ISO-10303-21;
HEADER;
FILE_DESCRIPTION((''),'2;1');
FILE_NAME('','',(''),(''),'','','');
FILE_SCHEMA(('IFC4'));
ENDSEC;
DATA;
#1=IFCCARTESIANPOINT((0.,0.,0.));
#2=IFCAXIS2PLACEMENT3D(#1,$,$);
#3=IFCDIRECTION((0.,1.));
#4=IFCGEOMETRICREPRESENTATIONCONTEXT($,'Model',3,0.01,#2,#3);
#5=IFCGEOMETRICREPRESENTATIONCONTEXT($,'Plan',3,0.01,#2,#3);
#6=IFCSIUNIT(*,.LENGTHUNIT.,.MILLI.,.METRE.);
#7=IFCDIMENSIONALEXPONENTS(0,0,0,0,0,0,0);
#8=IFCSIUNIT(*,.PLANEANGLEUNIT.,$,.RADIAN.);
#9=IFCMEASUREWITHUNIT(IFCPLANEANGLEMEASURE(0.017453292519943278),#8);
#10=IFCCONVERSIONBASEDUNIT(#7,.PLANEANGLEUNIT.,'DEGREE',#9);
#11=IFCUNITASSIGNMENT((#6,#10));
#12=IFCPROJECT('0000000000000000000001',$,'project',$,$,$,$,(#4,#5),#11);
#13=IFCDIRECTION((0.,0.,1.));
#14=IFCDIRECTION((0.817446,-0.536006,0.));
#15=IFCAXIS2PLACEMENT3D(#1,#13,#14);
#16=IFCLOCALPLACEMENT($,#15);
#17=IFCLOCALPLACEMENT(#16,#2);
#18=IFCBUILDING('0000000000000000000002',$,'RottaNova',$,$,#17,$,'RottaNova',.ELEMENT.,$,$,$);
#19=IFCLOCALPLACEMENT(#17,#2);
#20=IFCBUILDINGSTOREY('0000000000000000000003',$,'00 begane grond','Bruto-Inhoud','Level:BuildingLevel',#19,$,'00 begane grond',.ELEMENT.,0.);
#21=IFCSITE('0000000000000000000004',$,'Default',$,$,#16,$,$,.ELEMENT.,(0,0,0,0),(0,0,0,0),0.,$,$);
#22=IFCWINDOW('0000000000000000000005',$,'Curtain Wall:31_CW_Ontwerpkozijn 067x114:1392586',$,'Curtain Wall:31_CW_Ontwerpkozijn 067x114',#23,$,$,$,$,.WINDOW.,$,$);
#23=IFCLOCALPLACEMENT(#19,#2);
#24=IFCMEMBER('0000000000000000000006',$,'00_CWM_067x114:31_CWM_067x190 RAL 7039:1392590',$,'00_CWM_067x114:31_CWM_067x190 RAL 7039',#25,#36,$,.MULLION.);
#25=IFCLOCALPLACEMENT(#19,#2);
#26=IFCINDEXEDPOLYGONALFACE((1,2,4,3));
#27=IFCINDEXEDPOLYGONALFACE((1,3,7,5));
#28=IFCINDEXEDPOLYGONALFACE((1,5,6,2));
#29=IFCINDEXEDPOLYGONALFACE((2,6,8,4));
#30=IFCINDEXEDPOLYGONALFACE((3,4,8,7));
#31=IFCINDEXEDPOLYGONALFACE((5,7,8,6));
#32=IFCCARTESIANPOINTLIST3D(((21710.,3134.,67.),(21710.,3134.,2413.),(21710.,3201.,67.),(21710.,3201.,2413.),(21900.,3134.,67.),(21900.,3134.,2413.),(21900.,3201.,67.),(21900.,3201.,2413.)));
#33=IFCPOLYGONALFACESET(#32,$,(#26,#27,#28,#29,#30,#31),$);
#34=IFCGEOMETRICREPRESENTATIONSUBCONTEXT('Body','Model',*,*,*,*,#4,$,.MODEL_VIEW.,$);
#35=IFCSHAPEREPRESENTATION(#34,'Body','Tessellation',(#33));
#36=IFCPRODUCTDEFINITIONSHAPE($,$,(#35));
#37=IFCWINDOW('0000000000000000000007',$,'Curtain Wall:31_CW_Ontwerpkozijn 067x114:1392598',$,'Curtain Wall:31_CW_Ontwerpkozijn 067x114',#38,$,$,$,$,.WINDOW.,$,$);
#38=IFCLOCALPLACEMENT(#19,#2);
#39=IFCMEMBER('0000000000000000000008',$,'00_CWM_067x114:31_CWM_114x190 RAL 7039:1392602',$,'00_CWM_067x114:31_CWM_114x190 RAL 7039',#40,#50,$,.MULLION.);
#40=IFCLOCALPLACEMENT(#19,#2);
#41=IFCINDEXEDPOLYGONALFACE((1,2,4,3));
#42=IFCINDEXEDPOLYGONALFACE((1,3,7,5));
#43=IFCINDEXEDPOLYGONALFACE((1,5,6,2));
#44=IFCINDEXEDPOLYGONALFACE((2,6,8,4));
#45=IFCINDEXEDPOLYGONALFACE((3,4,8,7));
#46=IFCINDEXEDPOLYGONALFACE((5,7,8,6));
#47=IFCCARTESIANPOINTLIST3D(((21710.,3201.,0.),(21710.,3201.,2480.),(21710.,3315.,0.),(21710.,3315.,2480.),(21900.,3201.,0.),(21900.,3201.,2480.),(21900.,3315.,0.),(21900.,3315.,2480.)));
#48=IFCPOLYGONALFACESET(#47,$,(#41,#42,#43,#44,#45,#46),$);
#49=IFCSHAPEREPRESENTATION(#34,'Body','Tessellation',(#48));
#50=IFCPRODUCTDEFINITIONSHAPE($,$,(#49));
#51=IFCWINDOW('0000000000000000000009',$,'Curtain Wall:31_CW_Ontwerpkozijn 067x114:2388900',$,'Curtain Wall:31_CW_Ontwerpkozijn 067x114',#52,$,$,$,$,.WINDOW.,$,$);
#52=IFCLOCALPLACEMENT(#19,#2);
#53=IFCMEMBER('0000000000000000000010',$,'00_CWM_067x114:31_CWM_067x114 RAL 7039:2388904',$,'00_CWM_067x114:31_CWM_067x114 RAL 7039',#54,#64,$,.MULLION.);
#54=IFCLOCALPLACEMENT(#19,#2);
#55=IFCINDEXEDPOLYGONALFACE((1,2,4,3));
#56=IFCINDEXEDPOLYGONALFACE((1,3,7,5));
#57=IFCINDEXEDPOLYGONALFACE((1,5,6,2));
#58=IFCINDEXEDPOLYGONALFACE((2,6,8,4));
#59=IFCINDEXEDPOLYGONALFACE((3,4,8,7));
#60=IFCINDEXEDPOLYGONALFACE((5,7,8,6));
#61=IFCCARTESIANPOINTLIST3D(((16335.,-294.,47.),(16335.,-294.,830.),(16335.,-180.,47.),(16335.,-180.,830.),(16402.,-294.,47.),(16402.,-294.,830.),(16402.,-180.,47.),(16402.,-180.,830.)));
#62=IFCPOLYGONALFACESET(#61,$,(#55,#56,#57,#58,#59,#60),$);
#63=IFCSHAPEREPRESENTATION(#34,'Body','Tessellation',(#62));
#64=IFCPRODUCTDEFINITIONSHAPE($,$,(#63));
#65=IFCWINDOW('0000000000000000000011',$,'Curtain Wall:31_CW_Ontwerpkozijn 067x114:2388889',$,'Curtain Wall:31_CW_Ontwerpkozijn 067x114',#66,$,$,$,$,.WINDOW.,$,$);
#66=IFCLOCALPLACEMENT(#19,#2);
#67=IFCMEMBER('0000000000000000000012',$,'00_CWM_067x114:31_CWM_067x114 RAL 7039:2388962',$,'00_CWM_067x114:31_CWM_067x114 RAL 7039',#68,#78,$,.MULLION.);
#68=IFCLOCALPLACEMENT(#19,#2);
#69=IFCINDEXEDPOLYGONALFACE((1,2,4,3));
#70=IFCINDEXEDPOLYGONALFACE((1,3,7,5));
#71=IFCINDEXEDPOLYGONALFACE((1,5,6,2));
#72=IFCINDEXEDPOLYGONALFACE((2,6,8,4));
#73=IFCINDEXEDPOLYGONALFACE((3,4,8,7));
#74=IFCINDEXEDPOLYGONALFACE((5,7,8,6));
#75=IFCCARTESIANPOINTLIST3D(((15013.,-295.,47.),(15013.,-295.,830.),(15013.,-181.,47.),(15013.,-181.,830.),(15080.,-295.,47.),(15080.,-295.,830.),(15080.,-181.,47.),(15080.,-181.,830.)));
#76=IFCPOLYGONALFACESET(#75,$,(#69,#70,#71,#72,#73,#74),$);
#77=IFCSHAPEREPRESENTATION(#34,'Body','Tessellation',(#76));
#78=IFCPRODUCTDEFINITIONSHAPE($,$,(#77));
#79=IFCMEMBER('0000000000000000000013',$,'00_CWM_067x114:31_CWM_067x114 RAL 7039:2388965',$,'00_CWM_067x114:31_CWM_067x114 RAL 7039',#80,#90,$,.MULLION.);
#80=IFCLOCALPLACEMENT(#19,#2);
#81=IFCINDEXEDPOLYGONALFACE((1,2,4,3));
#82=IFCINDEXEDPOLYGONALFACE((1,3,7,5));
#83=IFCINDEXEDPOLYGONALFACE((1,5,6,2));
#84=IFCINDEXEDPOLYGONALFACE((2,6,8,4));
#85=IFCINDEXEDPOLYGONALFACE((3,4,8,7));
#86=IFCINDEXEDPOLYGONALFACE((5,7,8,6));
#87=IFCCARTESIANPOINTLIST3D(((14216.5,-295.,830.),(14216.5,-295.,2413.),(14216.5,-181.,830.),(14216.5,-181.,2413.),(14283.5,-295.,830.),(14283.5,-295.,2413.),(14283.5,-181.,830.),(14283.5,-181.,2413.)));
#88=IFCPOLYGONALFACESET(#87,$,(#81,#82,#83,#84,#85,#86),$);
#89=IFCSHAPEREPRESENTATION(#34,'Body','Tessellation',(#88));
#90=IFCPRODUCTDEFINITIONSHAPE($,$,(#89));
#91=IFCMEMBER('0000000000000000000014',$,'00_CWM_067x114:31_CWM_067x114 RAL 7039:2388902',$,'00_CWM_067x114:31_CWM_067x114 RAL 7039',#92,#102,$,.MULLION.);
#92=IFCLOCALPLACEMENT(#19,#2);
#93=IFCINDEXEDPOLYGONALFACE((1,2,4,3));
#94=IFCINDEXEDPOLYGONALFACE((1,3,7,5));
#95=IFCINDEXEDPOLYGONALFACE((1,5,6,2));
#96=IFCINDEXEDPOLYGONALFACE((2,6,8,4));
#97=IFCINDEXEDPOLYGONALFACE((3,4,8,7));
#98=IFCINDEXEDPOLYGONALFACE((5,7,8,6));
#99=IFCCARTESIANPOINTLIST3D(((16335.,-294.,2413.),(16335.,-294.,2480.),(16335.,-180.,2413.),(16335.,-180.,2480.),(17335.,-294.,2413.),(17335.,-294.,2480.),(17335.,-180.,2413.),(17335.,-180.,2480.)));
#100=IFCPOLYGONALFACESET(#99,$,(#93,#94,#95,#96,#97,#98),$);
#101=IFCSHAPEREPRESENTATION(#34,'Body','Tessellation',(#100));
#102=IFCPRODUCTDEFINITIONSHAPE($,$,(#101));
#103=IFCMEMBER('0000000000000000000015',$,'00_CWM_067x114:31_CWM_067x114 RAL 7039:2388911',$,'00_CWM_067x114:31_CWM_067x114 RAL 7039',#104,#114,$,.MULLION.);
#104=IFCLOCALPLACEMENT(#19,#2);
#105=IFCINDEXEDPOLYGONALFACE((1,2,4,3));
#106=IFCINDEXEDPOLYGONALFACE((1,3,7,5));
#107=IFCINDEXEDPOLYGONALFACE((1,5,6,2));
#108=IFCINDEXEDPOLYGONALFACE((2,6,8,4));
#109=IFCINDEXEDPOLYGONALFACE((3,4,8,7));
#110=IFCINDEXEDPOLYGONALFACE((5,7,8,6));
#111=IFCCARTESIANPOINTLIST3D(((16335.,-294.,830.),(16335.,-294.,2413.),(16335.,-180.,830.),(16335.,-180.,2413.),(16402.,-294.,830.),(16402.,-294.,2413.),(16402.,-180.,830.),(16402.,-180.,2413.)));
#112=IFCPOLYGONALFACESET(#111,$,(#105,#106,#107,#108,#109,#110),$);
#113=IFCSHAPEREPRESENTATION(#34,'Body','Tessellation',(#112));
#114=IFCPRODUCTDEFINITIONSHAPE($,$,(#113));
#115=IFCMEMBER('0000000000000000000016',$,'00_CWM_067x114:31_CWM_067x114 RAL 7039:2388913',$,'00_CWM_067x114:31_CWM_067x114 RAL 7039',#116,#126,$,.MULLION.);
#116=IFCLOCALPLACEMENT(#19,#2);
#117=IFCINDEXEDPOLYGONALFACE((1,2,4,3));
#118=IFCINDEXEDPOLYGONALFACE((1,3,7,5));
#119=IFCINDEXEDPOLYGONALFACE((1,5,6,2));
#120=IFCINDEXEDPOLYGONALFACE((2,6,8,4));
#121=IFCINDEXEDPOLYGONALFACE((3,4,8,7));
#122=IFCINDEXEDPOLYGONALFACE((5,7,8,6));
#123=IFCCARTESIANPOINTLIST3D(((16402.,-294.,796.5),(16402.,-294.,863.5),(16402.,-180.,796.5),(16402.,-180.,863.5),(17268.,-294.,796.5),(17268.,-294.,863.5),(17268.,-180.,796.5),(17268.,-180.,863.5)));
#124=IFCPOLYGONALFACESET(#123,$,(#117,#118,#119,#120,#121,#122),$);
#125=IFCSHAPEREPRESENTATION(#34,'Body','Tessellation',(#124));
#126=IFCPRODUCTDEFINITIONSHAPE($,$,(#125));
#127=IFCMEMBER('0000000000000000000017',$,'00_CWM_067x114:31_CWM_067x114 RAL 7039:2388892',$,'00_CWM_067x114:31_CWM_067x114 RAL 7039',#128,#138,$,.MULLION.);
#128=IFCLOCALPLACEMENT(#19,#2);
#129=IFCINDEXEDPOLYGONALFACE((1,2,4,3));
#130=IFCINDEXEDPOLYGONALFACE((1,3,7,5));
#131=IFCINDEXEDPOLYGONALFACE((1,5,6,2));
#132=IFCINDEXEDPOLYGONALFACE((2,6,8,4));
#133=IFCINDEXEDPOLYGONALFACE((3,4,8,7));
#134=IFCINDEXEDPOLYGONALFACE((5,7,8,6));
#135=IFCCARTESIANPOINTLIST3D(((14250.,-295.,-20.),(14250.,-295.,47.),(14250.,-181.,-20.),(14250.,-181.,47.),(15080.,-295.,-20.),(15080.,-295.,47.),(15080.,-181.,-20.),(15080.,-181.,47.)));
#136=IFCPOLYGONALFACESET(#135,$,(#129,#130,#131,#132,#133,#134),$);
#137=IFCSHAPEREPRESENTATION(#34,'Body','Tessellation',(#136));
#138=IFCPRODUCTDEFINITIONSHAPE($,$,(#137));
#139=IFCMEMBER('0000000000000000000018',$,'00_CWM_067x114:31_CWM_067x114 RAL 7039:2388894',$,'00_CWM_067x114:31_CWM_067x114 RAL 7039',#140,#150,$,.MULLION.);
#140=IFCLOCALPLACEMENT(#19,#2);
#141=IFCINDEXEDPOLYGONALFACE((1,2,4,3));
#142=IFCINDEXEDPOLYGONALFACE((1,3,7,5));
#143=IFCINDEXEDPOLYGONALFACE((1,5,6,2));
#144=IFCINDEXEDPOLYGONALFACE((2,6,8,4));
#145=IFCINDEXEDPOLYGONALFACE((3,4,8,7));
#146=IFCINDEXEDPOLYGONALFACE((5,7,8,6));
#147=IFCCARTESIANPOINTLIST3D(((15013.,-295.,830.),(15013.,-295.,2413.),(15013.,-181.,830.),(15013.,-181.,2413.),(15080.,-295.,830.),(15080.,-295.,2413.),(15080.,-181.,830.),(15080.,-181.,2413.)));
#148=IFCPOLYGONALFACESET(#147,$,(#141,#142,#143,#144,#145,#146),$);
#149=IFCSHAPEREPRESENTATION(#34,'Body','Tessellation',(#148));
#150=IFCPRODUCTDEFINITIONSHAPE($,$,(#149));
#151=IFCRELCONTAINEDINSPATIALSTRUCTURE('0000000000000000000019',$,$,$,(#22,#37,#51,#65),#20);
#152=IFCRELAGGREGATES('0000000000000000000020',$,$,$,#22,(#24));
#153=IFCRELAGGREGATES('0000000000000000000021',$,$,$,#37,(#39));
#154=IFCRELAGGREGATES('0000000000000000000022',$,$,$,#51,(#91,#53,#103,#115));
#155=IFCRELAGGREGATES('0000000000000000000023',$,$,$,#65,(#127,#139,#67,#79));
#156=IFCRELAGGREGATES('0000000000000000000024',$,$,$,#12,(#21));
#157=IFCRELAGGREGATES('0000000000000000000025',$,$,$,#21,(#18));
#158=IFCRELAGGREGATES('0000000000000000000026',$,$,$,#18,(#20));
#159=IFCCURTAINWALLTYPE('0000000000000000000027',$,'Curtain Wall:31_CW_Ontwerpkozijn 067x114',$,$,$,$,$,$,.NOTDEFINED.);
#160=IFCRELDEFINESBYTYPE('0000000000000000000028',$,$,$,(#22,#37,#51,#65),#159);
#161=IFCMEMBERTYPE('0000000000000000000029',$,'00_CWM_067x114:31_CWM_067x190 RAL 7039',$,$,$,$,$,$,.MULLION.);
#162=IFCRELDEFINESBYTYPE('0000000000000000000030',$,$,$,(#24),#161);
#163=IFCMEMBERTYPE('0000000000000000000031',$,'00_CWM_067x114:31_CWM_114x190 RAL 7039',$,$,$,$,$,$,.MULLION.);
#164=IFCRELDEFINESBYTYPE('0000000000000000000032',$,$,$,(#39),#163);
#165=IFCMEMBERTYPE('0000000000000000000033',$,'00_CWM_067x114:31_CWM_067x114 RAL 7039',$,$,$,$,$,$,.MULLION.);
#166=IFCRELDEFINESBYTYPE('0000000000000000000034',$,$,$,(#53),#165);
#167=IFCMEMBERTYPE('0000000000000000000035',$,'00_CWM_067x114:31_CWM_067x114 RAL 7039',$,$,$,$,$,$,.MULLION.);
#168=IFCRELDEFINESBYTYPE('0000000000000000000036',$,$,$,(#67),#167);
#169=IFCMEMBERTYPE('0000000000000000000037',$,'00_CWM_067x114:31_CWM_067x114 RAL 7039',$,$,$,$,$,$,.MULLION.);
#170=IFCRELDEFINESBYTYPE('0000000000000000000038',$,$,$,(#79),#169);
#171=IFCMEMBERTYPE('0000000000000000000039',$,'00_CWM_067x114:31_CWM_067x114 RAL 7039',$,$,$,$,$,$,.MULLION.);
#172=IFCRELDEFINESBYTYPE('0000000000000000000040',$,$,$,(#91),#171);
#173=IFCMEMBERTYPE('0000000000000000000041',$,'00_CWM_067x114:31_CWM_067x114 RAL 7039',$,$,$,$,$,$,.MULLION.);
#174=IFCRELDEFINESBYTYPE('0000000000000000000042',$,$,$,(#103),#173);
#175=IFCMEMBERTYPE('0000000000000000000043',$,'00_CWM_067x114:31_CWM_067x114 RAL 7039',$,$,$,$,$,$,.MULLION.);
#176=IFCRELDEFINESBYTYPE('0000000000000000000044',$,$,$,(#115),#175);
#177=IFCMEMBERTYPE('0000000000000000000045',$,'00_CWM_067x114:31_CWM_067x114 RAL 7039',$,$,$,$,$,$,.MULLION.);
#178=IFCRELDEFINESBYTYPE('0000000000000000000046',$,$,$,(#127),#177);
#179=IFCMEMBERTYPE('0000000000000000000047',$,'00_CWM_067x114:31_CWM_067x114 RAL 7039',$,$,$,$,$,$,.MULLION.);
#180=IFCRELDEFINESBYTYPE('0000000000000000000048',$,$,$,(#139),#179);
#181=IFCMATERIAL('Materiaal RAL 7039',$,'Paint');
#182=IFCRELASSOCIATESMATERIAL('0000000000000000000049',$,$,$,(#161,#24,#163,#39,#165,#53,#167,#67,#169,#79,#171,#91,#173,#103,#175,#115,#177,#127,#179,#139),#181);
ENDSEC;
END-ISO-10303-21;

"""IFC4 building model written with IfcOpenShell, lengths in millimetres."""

from ifc_helpers import new_model, entity, si_unit, converted_unit, direction, frame, origin, place, context, subcontext, project, spatial, indexed_curve, outline, extrude, source, transform, mapped, material, type_object, type_shapes, element, aggregate, save


model = new_model("IFC4")

# Units and contexts
model_context = context("Model", 3, precision=0.01, world=origin(), true_north=direction((0.0, 1.0)))
plan_context = context("Plan", 3, precision=0.01, world=origin(), true_north=direction((0.0, 1.0)))
body_context = subcontext(model_context, "Body", "Model", "MODEL_VIEW")
ifc_project = project(units=[si_unit("LENGTHUNIT", "METRE", prefix="MILLI"), converted_unit("PLANEANGLEUNIT", "DEGREE", entity("IfcPlaneAngleMeasure", 0.017453292519943278), si_unit("PLANEANGLEUNIT", "RADIAN"), dimensions=[0, 0, 0, 0, 0, 0, 0])], contexts=[model_context, plan_context])

# Site, building, storey
site_placement = place(None, frame((0.0, 0.0, 0.0), z_axis=(0.0, 0.0, 1.0), x_axis=(0.817446, -0.536006, 0.0)))
site = spatial("IfcSite", under=ifc_project, at=site_placement, Name="Default", CompositionType="ELEMENT", RefLatitude=(0, 0, 0, 0), RefLongitude=(0, 0, 0, 0), RefElevation=0.0)
building_placement = place(site_placement, origin())
building = spatial("IfcBuilding", under=site, at=building_placement, Name="RottaNova", LongName="RottaNova", CompositionType="ELEMENT")
storey_placement = place(building_placement, origin())
storey = spatial("IfcBuildingStorey", under=building, at=storey_placement, Name="00 begane grond", Description="Bruto-Inhoud", ObjectType="Level:BuildingLevel", LongName="00 begane grond", CompositionType="ELEMENT", Elevation=0.0)

# Windows, members
curtain_wall_type = type_object("IfcCurtainWallType", Name="Curtain Wall:31_CW_Ontwerpkozijn 067x114", PredefinedType="NOTDEFINED")
window_1_placement = place(storey_placement, origin())
window_1 = element("IfcWindow", 1, at=window_1_placement, inside=storey, type_object=curtain_wall_type, Name="Curtain Wall:31_CW_Ontwerpkozijn 067x114:1392586", ObjectType="Curtain Wall:31_CW_Ontwerpkozijn 067x114", PredefinedType="WINDOW")
ifc_material_1 = material(Name="Materiaal RAL 7039", Category="Paint")
member_type_1 = type_object("IfcMemberType", Name="00_CWM_067x114:31_CWM_067x190 RAL 7039", PredefinedType="MULLION", material=ifc_material_1)
shared_shape_1 = source(origin(), body_context, "Body", "SweptSolid", [
    extrude(outline(indexed_curve([(-33.5, -95.0), (33.5, -95.0), (33.5, 95.0), (-33.5, 95.0), (-33.5, -95.0)], self_intersect=False)), frame((-33.5, 95.0, -2346.0), z_axis=(0.0, 0.0, 1.0), x_axis=(-1.0, 0.0, 0.0)), (0.0, 0.0, 1.0), 2346.0),
])
type_shapes(member_type_1, [shared_shape_1])
member_1_placement = place(window_1_placement, frame((21710.0, 3201.0, 67.0), z_axis=(0.0, 0.0, -1.0), x_axis=(0.0, 1.0, 0.0)))
member_1 = element("IfcMember", 2, at=member_1_placement, type_object=member_type_1, material=ifc_material_1, Name="00_CWM_067x114:31_CWM_067x190 RAL 7039:1392590", ObjectType="00_CWM_067x114:31_CWM_067x190 RAL 7039", PredefinedType="MULLION", context=body_context, shape_type="MappedRepresentation", body=[
    mapped(shared_shape_1, transform((0.0, 0.0, 0.0), scale=1.0)),
])
aggregate(window_1, [member_1])
window_2_placement = place(storey_placement, origin())
window_2 = element("IfcWindow", 3, at=window_2_placement, inside=storey, type_object=curtain_wall_type, Name="Curtain Wall:31_CW_Ontwerpkozijn 067x114:1392598", ObjectType="Curtain Wall:31_CW_Ontwerpkozijn 067x114", PredefinedType="WINDOW")
member_type_2 = type_object("IfcMemberType", Name="00_CWM_067x114:31_CWM_114x190 RAL 7039", PredefinedType="MULLION", material=ifc_material_1)
shared_shape_2 = source(origin(), body_context, "Body", "SweptSolid", [
    extrude(outline(indexed_curve([(-57.0, -95.0), (57.0, -95.0), (57.0, 95.0), (-57.0, 95.0), (-57.0, -95.0)], self_intersect=False)), frame((-95.0, 0.0, -2480.0), z_axis=(0.0, 0.0, 1.0), x_axis=(0.0, -1.0, 0.0)), (0.0, 0.0, 1.0), 2480.0),
])
type_shapes(member_type_2, [shared_shape_2])
member_2_placement = place(window_2_placement, frame((21710.0, 3258.0, 2480.0), z_axis=(0.0, 0.0, 1.0), x_axis=(-1.0, 0.0, 0.0)))
member_2 = element("IfcMember", 4, at=member_2_placement, type_object=member_type_2, material=ifc_material_1, Name="00_CWM_067x114:31_CWM_114x190 RAL 7039:1392602", ObjectType="00_CWM_067x114:31_CWM_114x190 RAL 7039", PredefinedType="MULLION", context=body_context, shape_type="MappedRepresentation", body=[
    mapped(shared_shape_2, transform((0.0, 0.0, 0.0), scale=1.0)),
])
aggregate(window_2, [member_2])
window_3_placement = place(storey_placement, origin())
window_3 = element("IfcWindow", 5, at=window_3_placement, inside=storey, type_object=curtain_wall_type, Name="Curtain Wall:31_CW_Ontwerpkozijn 067x114:2388900", ObjectType="Curtain Wall:31_CW_Ontwerpkozijn 067x114", PredefinedType="WINDOW")
member_type_3 = type_object("IfcMemberType", Name="00_CWM_067x114:31_CWM_067x114 RAL 7039", PredefinedType="MULLION", material=ifc_material_1)
shared_shape_3 = source(origin(), body_context, "Body", "SweptSolid", [
    extrude(outline(indexed_curve([(-33.5, -57.0), (33.5, -57.0), (33.5, 57.0), (-33.5, 57.0), (-33.5, -57.0)], self_intersect=False)), frame((-33.5, -57.0, -783.0), z_axis=(0.0, 0.0, 1.0), x_axis=(-1.0, 0.0, 0.0)), (0.0, 0.0, 1.0), 783.0),
])
type_shapes(member_type_3, [shared_shape_3])
member_3_placement = place(window_3_placement, frame((16335.0, -180.0, 47.0), z_axis=(0.0, 0.0, -1.0), x_axis=(-1.0, 0.0, 0.0)))
member_3 = element("IfcMember", 6, at=member_3_placement, type_object=member_type_3, material=ifc_material_1, Name="00_CWM_067x114:31_CWM_067x114 RAL 7039:2388904", ObjectType="00_CWM_067x114:31_CWM_067x114 RAL 7039", PredefinedType="MULLION", context=body_context, shape_type="MappedRepresentation", body=[
    mapped(shared_shape_3, transform((0.0, 0.0, 0.0), scale=1.0)),
])

# Window, members
window_4_placement = place(storey_placement, origin())
window_4 = element("IfcWindow", 7, at=window_4_placement, inside=storey, type_object=curtain_wall_type, Name="Curtain Wall:31_CW_Ontwerpkozijn 067x114:2388889", ObjectType="Curtain Wall:31_CW_Ontwerpkozijn 067x114", PredefinedType="WINDOW")
member_type_4 = type_object("IfcMemberType", Name="00_CWM_067x114:31_CWM_067x114 RAL 7039", PredefinedType="MULLION", material=ifc_material_1)
shared_shape_4 = source(origin(), body_context, "Body", "SweptSolid", [
    extrude(outline(indexed_curve([(-33.5, -57.0), (33.5, -57.0), (33.5, 57.0), (-33.5, 57.0), (-33.5, -57.0)], self_intersect=False)), frame((-33.5, -57.0, -783.0), z_axis=(0.0, 0.0, 1.0), x_axis=(-1.0, 0.0, 0.0)), (0.0, 0.0, 1.0), 783.0),
])
type_shapes(member_type_4, [shared_shape_4])
member_4_placement = place(window_4_placement, frame((15080.0, -181.0, 830.0)))
member_4 = element("IfcMember", 8, at=member_4_placement, type_object=member_type_4, material=ifc_material_1, Name="00_CWM_067x114:31_CWM_067x114 RAL 7039:2388962", ObjectType="00_CWM_067x114:31_CWM_067x114 RAL 7039", PredefinedType="MULLION", context=body_context, shape_type="MappedRepresentation", body=[
    mapped(shared_shape_4, transform((0.0, 0.0, 0.0), scale=1.0)),
])
member_type_5 = type_object("IfcMemberType", Name="00_CWM_067x114:31_CWM_067x114 RAL 7039", PredefinedType="MULLION", material=ifc_material_1)
shared_shape_5 = source(origin(), body_context, "Body", "SweptSolid", [
    extrude(outline(indexed_curve([(-33.5, -57.0), (33.5, -57.0), (33.5, 57.0), (-33.5, 57.0), (-33.5, -57.0)], self_intersect=False)), frame((0.0, -57.0, -1583.0), z_axis=(0.0, 0.0, 1.0), x_axis=(-1.0, 0.0, 0.0)), (0.0, 0.0, 1.0), 1583.0),
])
type_shapes(member_type_5, [shared_shape_5])
member_5_placement = place(window_4_placement, frame((14250.0, -181.0, 830.0), z_axis=(0.0, 0.0, -1.0), x_axis=(-1.0, 0.0, 0.0)))
member_5 = element("IfcMember", 9, at=member_5_placement, type_object=member_type_5, material=ifc_material_1, Name="00_CWM_067x114:31_CWM_067x114 RAL 7039:2388965", ObjectType="00_CWM_067x114:31_CWM_067x114 RAL 7039", PredefinedType="MULLION", context=body_context, shape_type="MappedRepresentation", body=[
    mapped(shared_shape_5, transform((0.0, 0.0, 0.0), scale=1.0)),
])

# Members
member_type_6 = type_object("IfcMemberType", Name="00_CWM_067x114:31_CWM_067x114 RAL 7039", PredefinedType="MULLION", material=ifc_material_1)
shared_shape_6 = source(origin(), body_context, "Body", "SweptSolid", [
    extrude(outline(indexed_curve([(-33.5, -57.0), (33.5, -57.0), (33.5, 57.0), (-33.5, 57.0), (-33.5, -57.0)], self_intersect=False)), frame((-33.5, -57.0, -1000.0), z_axis=(0.0, 0.0, 1.0), x_axis=(-1.0, 0.0, 0.0)), (0.0, 0.0, 1.0), 1000.0),
])
type_shapes(member_type_6, [shared_shape_6])
member_6_placement = place(window_3_placement, frame((16335.0, -180.0, 2480.0), z_axis=(-1.0, 0.0, 0.0), x_axis=(0.0, 0.0, 1.0)))
member_6 = element("IfcMember", 10, at=member_6_placement, type_object=member_type_6, material=ifc_material_1, Name="00_CWM_067x114:31_CWM_067x114 RAL 7039:2388902", ObjectType="00_CWM_067x114:31_CWM_067x114 RAL 7039", PredefinedType="MULLION", context=body_context, shape_type="MappedRepresentation", body=[
    mapped(shared_shape_6, transform((0.0, 0.0, 0.0), scale=1.0)),
])
member_type_7 = type_object("IfcMemberType", Name="00_CWM_067x114:31_CWM_067x114 RAL 7039", PredefinedType="MULLION", material=ifc_material_1)
shared_shape_7 = source(origin(), body_context, "Body", "SweptSolid", [
    extrude(outline(indexed_curve([(-33.5, -57.0), (33.5, -57.0), (33.5, 57.0), (-33.5, 57.0), (-33.5, -57.0)], self_intersect=False)), frame((-33.5, -57.0, -1583.0), z_axis=(0.0, 0.0, 1.0), x_axis=(-1.0, 0.0, 0.0)), (0.0, 0.0, 1.0), 1583.0),
])
type_shapes(member_type_7, [shared_shape_7])
member_7_placement = place(window_3_placement, frame((16335.0, -180.0, 830.0), z_axis=(0.0, 0.0, -1.0), x_axis=(-1.0, 0.0, 0.0)))
member_7 = element("IfcMember", 11, at=member_7_placement, type_object=member_type_7, material=ifc_material_1, Name="00_CWM_067x114:31_CWM_067x114 RAL 7039:2388911", ObjectType="00_CWM_067x114:31_CWM_067x114 RAL 7039", PredefinedType="MULLION", context=body_context, shape_type="MappedRepresentation", body=[
    mapped(shared_shape_7, transform((0.0, 0.0, 0.0), scale=1.0)),
])
member_type_8 = type_object("IfcMemberType", Name="00_CWM_067x114:31_CWM_067x114 RAL 7039", PredefinedType="MULLION", material=ifc_material_1)
shared_shape_8 = source(origin(), body_context, "Body", "SweptSolid", [
    extrude(outline(indexed_curve([(-33.5, -57.0), (33.5, -57.0), (33.5, 57.0), (-33.5, 57.0), (-33.5, -57.0)], self_intersect=False)), frame((0.0, -57.0, -866.0), z_axis=(0.0, 0.0, 1.0), x_axis=(-1.0, 0.0, 0.0)), (0.0, 0.0, 1.0), 866.0),
])
type_shapes(member_type_8, [shared_shape_8])
member_8_placement = place(window_3_placement, frame((16402.0, -180.0, 830.0), z_axis=(-1.0, 0.0, 0.0), x_axis=(0.0, 0.0, 1.0)))
member_8 = element("IfcMember", 12, at=member_8_placement, type_object=member_type_8, material=ifc_material_1, Name="00_CWM_067x114:31_CWM_067x114 RAL 7039:2388913", ObjectType="00_CWM_067x114:31_CWM_067x114 RAL 7039", PredefinedType="MULLION", context=body_context, shape_type="MappedRepresentation", body=[
    mapped(shared_shape_8, transform((0.0, 0.0, 0.0), scale=1.0)),
])
aggregate(window_3, [member_6, member_3, member_7, member_8])
member_type_9 = type_object("IfcMemberType", Name="00_CWM_067x114:31_CWM_067x114 RAL 7039", PredefinedType="MULLION", material=ifc_material_1)
shared_shape_9 = source(origin(), body_context, "Body", "SweptSolid", [
    extrude(outline(indexed_curve([(-33.5, -57.0), (33.5, -57.0), (33.5, 57.0), (-33.5, 57.0), (-33.5, -57.0)], self_intersect=False)), frame((-33.5, -57.0, -830.0), z_axis=(0.0, 0.0, 1.0), x_axis=(-1.0, 0.0, 0.0)), (0.0, 0.0, 1.0), 830.0),
])
type_shapes(member_type_9, [shared_shape_9])
member_9_placement = place(window_4_placement, frame((15080.0, -181.0, -20.0), z_axis=(1.0, 0.0, 0.0), x_axis=(0.0, 0.0, -1.0)))
member_9 = element("IfcMember", 13, at=member_9_placement, type_object=member_type_9, material=ifc_material_1, Name="00_CWM_067x114:31_CWM_067x114 RAL 7039:2388892", ObjectType="00_CWM_067x114:31_CWM_067x114 RAL 7039", PredefinedType="MULLION", context=body_context, shape_type="MappedRepresentation", body=[
    mapped(shared_shape_9, transform((0.0, 0.0, 0.0), scale=1.0)),
])
member_type_10 = type_object("IfcMemberType", Name="00_CWM_067x114:31_CWM_067x114 RAL 7039", PredefinedType="MULLION", material=ifc_material_1)
shared_shape_10 = source(origin(), body_context, "Body", "SweptSolid", [
    extrude(outline(indexed_curve([(-33.5, -57.0), (33.5, -57.0), (33.5, 57.0), (-33.5, 57.0), (-33.5, -57.0)], self_intersect=False)), frame((-33.5, -57.0, -1583.0), z_axis=(0.0, 0.0, 1.0), x_axis=(-1.0, 0.0, 0.0)), (0.0, 0.0, 1.0), 1583.0),
])
type_shapes(member_type_10, [shared_shape_10])
member_10_placement = place(window_4_placement, frame((15080.0, -181.0, 2413.0)))
member_10 = element("IfcMember", 14, at=member_10_placement, type_object=member_type_10, material=ifc_material_1, Name="00_CWM_067x114:31_CWM_067x114 RAL 7039:2388894", ObjectType="00_CWM_067x114:31_CWM_067x114 RAL 7039", PredefinedType="MULLION", context=body_context, shape_type="MappedRepresentation", body=[
    mapped(shared_shape_10, transform((0.0, 0.0, 0.0), scale=1.0)),
])

aggregate(window_4, [member_9, member_10, member_4, member_5])

save(model, "model.ifc")
